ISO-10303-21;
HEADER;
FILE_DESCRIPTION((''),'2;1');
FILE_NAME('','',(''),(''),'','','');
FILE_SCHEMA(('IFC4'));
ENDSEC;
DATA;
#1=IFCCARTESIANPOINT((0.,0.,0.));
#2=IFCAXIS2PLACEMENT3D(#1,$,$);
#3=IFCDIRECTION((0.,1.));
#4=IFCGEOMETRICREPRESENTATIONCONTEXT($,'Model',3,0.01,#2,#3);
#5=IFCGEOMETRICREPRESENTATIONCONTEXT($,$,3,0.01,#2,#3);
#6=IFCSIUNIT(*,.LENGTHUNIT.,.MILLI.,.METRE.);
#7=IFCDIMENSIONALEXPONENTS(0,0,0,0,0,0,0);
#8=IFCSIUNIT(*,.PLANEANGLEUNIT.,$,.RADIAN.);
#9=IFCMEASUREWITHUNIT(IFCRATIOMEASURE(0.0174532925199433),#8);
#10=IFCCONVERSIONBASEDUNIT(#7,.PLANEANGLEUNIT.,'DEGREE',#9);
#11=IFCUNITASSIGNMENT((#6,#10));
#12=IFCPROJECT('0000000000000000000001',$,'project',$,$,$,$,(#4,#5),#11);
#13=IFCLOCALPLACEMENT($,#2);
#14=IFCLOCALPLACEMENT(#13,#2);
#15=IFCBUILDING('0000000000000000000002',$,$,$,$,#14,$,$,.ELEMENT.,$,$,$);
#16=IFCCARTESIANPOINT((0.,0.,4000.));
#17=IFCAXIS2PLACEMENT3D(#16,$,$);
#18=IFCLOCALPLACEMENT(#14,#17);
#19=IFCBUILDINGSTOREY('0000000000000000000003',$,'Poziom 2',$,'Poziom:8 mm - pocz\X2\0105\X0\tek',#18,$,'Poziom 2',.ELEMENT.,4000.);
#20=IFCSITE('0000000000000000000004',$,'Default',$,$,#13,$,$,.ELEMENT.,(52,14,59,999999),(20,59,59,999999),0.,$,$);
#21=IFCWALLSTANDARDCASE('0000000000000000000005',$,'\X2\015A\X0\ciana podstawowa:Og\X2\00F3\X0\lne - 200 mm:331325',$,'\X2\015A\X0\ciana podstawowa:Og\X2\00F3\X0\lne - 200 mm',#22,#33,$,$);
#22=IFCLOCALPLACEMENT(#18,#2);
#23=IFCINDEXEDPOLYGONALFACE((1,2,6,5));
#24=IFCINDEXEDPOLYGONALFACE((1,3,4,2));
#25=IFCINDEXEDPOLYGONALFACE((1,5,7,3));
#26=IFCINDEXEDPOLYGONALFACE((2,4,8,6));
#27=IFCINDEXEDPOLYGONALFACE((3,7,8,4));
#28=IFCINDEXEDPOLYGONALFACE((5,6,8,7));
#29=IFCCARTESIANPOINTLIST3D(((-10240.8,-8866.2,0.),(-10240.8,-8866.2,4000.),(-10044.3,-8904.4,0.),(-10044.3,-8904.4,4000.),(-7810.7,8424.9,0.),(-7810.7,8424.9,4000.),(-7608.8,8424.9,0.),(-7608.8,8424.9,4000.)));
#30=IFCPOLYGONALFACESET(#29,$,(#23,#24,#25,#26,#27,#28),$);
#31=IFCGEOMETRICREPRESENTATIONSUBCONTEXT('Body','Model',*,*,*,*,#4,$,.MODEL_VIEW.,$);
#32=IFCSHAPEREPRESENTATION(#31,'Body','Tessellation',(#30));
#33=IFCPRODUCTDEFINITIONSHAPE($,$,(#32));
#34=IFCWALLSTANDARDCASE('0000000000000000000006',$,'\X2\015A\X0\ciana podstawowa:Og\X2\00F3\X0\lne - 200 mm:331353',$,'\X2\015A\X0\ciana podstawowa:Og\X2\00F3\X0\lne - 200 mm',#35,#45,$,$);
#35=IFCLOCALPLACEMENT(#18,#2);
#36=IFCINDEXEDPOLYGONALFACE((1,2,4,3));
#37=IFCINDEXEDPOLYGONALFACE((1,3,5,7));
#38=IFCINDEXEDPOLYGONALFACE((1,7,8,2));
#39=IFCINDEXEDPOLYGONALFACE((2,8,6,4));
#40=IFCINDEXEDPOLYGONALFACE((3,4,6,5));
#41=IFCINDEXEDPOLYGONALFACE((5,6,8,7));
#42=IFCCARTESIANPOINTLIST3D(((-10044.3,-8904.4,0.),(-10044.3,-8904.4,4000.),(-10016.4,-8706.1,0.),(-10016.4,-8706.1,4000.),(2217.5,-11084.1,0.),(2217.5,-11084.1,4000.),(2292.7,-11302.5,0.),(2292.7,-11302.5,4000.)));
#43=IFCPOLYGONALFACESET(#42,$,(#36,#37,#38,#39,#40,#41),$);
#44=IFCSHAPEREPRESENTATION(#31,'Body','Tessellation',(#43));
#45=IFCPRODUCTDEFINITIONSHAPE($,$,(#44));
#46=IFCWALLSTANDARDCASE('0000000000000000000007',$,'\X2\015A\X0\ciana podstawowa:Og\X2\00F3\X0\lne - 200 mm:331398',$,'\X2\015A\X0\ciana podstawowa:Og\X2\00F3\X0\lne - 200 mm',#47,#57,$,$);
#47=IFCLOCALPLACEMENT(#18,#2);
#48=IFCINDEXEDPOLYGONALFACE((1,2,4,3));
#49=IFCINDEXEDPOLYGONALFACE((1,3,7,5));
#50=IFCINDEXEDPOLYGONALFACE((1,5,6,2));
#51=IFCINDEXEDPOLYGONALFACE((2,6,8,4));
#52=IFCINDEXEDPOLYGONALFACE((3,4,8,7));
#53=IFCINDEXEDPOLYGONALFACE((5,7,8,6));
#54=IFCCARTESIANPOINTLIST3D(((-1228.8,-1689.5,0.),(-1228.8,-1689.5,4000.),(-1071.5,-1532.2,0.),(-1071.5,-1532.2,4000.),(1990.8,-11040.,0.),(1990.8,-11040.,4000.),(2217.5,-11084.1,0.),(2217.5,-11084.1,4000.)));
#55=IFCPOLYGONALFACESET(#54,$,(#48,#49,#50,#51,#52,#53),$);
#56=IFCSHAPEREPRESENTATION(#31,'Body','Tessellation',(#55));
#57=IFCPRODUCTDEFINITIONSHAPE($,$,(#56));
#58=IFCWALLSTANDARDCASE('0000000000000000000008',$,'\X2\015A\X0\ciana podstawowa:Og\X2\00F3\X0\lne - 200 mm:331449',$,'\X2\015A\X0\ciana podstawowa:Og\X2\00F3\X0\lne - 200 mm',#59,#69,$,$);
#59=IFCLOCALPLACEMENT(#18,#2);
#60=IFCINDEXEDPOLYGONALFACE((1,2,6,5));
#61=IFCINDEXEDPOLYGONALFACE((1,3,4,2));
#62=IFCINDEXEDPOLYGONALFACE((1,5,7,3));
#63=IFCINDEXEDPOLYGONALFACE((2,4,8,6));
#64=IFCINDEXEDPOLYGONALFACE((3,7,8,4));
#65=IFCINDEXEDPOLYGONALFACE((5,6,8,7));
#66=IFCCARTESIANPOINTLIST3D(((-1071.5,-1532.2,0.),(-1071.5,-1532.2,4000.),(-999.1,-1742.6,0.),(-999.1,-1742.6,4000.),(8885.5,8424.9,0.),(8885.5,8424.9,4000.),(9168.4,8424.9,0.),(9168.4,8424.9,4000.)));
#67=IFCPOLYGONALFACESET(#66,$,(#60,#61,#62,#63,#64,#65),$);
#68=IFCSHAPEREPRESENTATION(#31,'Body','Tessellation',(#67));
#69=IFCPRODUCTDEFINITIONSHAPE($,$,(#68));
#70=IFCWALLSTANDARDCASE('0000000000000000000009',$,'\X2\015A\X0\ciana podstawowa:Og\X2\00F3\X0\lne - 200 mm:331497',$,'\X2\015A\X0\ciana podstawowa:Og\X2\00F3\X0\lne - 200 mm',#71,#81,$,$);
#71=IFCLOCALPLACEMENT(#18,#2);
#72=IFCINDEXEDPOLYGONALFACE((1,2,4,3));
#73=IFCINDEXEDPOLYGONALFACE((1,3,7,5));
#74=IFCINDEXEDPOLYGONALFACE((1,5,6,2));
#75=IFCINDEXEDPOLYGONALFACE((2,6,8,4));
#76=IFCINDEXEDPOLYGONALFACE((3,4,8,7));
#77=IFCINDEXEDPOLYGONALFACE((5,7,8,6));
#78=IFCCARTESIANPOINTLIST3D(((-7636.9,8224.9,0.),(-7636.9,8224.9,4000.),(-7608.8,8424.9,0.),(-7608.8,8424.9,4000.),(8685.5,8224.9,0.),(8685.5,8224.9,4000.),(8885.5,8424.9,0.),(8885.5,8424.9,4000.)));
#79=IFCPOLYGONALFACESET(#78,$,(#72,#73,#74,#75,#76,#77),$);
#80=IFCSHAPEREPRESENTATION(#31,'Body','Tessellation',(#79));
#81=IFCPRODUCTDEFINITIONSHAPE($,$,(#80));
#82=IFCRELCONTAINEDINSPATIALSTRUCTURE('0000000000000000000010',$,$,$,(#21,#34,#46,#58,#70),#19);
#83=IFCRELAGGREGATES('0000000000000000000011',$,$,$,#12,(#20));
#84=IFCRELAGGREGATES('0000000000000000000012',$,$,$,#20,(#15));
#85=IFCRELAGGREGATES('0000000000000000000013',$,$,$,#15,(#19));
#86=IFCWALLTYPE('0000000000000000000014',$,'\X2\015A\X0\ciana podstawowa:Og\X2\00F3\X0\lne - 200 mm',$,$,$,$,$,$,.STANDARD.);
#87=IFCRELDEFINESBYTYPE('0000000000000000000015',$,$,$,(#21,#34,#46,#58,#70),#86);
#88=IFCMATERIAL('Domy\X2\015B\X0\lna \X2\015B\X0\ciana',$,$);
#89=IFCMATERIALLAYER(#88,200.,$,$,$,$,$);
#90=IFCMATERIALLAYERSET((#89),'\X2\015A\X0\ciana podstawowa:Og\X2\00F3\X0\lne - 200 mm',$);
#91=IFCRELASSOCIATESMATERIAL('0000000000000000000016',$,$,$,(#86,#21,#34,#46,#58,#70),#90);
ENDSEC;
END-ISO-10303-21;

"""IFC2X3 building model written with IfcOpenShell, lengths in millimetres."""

from ifc_helpers import new_model, entity, si_unit, converted_unit, direction, frame, origin, place, context, subcontext, project, spatial, polyline, outline, extrude, clip, halfspace, material, layer, layer_set, layer_usage, type_object, element, save


model = new_model("IFC2X3")

# Units and contexts
model_context = context("Model", 3, precision=0.01, world=origin(), true_north=direction((0.0, 1.0)))
context_of_model = context(None, 3, precision=0.01, world=origin(), true_north=direction((0.0, 1.0)))
body_context = subcontext(model_context, "Body", "Model", "MODEL_VIEW")
ifc_project = project(units=[si_unit("LENGTHUNIT", "METRE", prefix="MILLI"), converted_unit("PLANEANGLEUNIT", "DEGREE", entity("IfcRatioMeasure", 0.0174532925199433), si_unit("PLANEANGLEUNIT", "RADIAN"), dimensions=[0, 0, 0, 0, 0, 0, 0])], contexts=[model_context, context_of_model])

# Site, building, storey
site_placement = place(None, origin())
site = spatial("IfcSite", under=ifc_project, at=site_placement, Name="Default", CompositionType="ELEMENT", RefLatitude=(52, 14, 59, 999999), RefLongitude=(20, 59, 59, 999999), RefElevation=0.0)
building_placement = place(site_placement, origin())
building = spatial("IfcBuilding", under=site, at=building_placement, CompositionType="ELEMENT")
storey_placement = place(building_placement, frame((0.0, 0.0, 4000.0)))
storey = spatial("IfcBuildingStorey", under=building, at=storey_placement, Name="Poziom 2", ObjectType="Poziom:8 mm - początek", LongName="Poziom 2", CompositionType="ELEMENT", Elevation=4000.0)

# Walls
ifc_material = material(Name="Domyślna ściana")
ifc_layer = layer(ifc_material, 200.0)
ifc_layer_set = layer_set([ifc_layer], Name="Ściana podstawowa:Ogólne - 200 mm")
ifc_layer_usage_1 = layer_usage(ifc_layer_set, "AXIS2", "NEGATIVE", 100.0)
wall_type = type_object("IfcWallType", Name="Ściana podstawowa:Ogólne - 200 mm", PredefinedType="STANDARD", material=ifc_layer_set)
wall_1_placement = place(storey_placement, frame((-7707.8, 8438.8, 0.0), z_axis=(0.0, 0.0, 1.0), x_axis=(-0.139173, -0.990268, 0.0)))
element("IfcWallStandardCase", 1, at=wall_1_placement, inside=storey, type_object=wall_type, material=ifc_layer_usage_1, Name="Ściana podstawowa:Ogólne - 200 mm:331325", ObjectType="Ściana podstawowa:Ogólne - 200 mm", context=body_context, shape_type="Clipping", body=[
    clip(extrude(outline(polyline([(17489.1, -100.0), (17499.6, 100.0), (17299.3, 100.0), (202.0, 100.0), (0.0, 100.0), (28.1, -100.0), (17489.1, -100.0)])), origin(), (0.0, 0.0, 1.0), 4000.0), halfspace(frame((0.0, 0.0, -4000.0)), True)),
])
ifc_layer_usage_2 = layer_usage(ifc_layer_set, "AXIS2", "NEGATIVE", 100.0)
wall_2_placement = place(storey_placement, frame((-10035.5, -8804.2, 0.0), z_axis=(0.0, 0.0, 1.0), x_axis=(0.981627, -0.190809, 0.0)))
element("IfcWallStandardCase", 2, at=wall_2_placement, inside=storey, type_object=wall_type, material=ifc_layer_usage_2, Name="Ściana podstawowa:Ogólne - 200 mm:331353", ObjectType="Ściana podstawowa:Ogólne - 200 mm", context=body_context, shape_type="Clipping", body=[
    clip(extrude(outline(polyline([(10.5, -100.0), (12578.3, -100.0), (12462.8, 100.0), (12231.9, 100.0), (0.0, 100.0), (10.5, -100.0)])), origin(), (0.0, 0.0, 1.0), 4000.0), halfspace(frame((0.0, 0.0, -4000.0)), True)),
])
ifc_layer_usage_3 = layer_usage(ifc_layer_set, "AXIS2", "NEGATIVE", 100.0)
wall_3_placement = place(storey_placement, frame((2122.9, -11116.7, 0.0), z_axis=(0.0, 0.0, 1.0), x_axis=(-0.325568, 0.945519, 0.0)))
element("IfcWallStandardCase", 3, at=wall_3_placement, inside=storey, type_object=wall_type, material=ifc_layer_usage_3, Name="Ściana podstawowa:Ogólne - 200 mm:331398", ObjectType="Ściana podstawowa:Ogólne - 200 mm", context=body_context, shape_type="Clipping", body=[
    clip(extrude(outline(polyline([(10102.3, -100.0), (10004.8, 100.0), (115.5, 100.0), (0.0, -100.0), (9879.8, -100.0), (10102.3, -100.0)])), origin(), (0.0, 0.0, 1.0), 4000.0), halfspace(frame((0.0, 0.0, -4000.0)), True)),
])
ifc_layer_usage_4 = layer_usage(ifc_layer_set, "AXIS2", "NEGATIVE", 100.0)
wall_4_placement = place(storey_placement, frame((-1069.8, -1671.9, 0.0), z_axis=(0.0, 0.0, 1.0), x_axis=(0.707107, 0.707107, 0.0)))
element("IfcWallStandardCase", 4, at=wall_4_placement, inside=storey, type_object=wall_type, material=ifc_layer_usage_4, Name="Ściana podstawowa:Ogólne - 200 mm:331449", ObjectType="Ściana podstawowa:Ogólne - 200 mm", context=body_context, shape_type="Clipping", body=[
    clip(extrude(outline(polyline([(14378.9, -100.0), (14178.9, 100.0), (13896.1, 100.0), (97.5, 100.0), (0.0, -100.0), (14378.9, -100.0)])), origin(), (0.0, 0.0, 1.0), 4000.0), halfspace(frame((0.0, 0.0, -4000.0)), True)),
])
ifc_layer_usage_5 = layer_usage(ifc_layer_set, "AXIS2", "NEGATIVE", 100.0)
wall_5_placement = place(storey_placement, frame((8885.5, 8324.9, 0.0), z_axis=(0.0, 0.0, 1.0), x_axis=(-1.0, 0.0, 0.0)))
element("IfcWallStandardCase", 5, at=wall_5_placement, inside=storey, type_object=wall_type, material=ifc_layer_usage_5, Name="Ściana podstawowa:Ogólne - 200 mm:331497", ObjectType="Ściana podstawowa:Ogólne - 200 mm", context=body_context, shape_type="Clipping", body=[
    clip(extrude(outline(polyline([(16494.3, -100.0), (16522.4, 100.0), (200.0, 100.0), (0.0, -100.0), (16494.3, -100.0)])), origin(), (0.0, 0.0, 1.0), 4000.0), halfspace(frame((0.0, 0.0, -4000.0)), True)),
])

save(model, "model.ifc")
